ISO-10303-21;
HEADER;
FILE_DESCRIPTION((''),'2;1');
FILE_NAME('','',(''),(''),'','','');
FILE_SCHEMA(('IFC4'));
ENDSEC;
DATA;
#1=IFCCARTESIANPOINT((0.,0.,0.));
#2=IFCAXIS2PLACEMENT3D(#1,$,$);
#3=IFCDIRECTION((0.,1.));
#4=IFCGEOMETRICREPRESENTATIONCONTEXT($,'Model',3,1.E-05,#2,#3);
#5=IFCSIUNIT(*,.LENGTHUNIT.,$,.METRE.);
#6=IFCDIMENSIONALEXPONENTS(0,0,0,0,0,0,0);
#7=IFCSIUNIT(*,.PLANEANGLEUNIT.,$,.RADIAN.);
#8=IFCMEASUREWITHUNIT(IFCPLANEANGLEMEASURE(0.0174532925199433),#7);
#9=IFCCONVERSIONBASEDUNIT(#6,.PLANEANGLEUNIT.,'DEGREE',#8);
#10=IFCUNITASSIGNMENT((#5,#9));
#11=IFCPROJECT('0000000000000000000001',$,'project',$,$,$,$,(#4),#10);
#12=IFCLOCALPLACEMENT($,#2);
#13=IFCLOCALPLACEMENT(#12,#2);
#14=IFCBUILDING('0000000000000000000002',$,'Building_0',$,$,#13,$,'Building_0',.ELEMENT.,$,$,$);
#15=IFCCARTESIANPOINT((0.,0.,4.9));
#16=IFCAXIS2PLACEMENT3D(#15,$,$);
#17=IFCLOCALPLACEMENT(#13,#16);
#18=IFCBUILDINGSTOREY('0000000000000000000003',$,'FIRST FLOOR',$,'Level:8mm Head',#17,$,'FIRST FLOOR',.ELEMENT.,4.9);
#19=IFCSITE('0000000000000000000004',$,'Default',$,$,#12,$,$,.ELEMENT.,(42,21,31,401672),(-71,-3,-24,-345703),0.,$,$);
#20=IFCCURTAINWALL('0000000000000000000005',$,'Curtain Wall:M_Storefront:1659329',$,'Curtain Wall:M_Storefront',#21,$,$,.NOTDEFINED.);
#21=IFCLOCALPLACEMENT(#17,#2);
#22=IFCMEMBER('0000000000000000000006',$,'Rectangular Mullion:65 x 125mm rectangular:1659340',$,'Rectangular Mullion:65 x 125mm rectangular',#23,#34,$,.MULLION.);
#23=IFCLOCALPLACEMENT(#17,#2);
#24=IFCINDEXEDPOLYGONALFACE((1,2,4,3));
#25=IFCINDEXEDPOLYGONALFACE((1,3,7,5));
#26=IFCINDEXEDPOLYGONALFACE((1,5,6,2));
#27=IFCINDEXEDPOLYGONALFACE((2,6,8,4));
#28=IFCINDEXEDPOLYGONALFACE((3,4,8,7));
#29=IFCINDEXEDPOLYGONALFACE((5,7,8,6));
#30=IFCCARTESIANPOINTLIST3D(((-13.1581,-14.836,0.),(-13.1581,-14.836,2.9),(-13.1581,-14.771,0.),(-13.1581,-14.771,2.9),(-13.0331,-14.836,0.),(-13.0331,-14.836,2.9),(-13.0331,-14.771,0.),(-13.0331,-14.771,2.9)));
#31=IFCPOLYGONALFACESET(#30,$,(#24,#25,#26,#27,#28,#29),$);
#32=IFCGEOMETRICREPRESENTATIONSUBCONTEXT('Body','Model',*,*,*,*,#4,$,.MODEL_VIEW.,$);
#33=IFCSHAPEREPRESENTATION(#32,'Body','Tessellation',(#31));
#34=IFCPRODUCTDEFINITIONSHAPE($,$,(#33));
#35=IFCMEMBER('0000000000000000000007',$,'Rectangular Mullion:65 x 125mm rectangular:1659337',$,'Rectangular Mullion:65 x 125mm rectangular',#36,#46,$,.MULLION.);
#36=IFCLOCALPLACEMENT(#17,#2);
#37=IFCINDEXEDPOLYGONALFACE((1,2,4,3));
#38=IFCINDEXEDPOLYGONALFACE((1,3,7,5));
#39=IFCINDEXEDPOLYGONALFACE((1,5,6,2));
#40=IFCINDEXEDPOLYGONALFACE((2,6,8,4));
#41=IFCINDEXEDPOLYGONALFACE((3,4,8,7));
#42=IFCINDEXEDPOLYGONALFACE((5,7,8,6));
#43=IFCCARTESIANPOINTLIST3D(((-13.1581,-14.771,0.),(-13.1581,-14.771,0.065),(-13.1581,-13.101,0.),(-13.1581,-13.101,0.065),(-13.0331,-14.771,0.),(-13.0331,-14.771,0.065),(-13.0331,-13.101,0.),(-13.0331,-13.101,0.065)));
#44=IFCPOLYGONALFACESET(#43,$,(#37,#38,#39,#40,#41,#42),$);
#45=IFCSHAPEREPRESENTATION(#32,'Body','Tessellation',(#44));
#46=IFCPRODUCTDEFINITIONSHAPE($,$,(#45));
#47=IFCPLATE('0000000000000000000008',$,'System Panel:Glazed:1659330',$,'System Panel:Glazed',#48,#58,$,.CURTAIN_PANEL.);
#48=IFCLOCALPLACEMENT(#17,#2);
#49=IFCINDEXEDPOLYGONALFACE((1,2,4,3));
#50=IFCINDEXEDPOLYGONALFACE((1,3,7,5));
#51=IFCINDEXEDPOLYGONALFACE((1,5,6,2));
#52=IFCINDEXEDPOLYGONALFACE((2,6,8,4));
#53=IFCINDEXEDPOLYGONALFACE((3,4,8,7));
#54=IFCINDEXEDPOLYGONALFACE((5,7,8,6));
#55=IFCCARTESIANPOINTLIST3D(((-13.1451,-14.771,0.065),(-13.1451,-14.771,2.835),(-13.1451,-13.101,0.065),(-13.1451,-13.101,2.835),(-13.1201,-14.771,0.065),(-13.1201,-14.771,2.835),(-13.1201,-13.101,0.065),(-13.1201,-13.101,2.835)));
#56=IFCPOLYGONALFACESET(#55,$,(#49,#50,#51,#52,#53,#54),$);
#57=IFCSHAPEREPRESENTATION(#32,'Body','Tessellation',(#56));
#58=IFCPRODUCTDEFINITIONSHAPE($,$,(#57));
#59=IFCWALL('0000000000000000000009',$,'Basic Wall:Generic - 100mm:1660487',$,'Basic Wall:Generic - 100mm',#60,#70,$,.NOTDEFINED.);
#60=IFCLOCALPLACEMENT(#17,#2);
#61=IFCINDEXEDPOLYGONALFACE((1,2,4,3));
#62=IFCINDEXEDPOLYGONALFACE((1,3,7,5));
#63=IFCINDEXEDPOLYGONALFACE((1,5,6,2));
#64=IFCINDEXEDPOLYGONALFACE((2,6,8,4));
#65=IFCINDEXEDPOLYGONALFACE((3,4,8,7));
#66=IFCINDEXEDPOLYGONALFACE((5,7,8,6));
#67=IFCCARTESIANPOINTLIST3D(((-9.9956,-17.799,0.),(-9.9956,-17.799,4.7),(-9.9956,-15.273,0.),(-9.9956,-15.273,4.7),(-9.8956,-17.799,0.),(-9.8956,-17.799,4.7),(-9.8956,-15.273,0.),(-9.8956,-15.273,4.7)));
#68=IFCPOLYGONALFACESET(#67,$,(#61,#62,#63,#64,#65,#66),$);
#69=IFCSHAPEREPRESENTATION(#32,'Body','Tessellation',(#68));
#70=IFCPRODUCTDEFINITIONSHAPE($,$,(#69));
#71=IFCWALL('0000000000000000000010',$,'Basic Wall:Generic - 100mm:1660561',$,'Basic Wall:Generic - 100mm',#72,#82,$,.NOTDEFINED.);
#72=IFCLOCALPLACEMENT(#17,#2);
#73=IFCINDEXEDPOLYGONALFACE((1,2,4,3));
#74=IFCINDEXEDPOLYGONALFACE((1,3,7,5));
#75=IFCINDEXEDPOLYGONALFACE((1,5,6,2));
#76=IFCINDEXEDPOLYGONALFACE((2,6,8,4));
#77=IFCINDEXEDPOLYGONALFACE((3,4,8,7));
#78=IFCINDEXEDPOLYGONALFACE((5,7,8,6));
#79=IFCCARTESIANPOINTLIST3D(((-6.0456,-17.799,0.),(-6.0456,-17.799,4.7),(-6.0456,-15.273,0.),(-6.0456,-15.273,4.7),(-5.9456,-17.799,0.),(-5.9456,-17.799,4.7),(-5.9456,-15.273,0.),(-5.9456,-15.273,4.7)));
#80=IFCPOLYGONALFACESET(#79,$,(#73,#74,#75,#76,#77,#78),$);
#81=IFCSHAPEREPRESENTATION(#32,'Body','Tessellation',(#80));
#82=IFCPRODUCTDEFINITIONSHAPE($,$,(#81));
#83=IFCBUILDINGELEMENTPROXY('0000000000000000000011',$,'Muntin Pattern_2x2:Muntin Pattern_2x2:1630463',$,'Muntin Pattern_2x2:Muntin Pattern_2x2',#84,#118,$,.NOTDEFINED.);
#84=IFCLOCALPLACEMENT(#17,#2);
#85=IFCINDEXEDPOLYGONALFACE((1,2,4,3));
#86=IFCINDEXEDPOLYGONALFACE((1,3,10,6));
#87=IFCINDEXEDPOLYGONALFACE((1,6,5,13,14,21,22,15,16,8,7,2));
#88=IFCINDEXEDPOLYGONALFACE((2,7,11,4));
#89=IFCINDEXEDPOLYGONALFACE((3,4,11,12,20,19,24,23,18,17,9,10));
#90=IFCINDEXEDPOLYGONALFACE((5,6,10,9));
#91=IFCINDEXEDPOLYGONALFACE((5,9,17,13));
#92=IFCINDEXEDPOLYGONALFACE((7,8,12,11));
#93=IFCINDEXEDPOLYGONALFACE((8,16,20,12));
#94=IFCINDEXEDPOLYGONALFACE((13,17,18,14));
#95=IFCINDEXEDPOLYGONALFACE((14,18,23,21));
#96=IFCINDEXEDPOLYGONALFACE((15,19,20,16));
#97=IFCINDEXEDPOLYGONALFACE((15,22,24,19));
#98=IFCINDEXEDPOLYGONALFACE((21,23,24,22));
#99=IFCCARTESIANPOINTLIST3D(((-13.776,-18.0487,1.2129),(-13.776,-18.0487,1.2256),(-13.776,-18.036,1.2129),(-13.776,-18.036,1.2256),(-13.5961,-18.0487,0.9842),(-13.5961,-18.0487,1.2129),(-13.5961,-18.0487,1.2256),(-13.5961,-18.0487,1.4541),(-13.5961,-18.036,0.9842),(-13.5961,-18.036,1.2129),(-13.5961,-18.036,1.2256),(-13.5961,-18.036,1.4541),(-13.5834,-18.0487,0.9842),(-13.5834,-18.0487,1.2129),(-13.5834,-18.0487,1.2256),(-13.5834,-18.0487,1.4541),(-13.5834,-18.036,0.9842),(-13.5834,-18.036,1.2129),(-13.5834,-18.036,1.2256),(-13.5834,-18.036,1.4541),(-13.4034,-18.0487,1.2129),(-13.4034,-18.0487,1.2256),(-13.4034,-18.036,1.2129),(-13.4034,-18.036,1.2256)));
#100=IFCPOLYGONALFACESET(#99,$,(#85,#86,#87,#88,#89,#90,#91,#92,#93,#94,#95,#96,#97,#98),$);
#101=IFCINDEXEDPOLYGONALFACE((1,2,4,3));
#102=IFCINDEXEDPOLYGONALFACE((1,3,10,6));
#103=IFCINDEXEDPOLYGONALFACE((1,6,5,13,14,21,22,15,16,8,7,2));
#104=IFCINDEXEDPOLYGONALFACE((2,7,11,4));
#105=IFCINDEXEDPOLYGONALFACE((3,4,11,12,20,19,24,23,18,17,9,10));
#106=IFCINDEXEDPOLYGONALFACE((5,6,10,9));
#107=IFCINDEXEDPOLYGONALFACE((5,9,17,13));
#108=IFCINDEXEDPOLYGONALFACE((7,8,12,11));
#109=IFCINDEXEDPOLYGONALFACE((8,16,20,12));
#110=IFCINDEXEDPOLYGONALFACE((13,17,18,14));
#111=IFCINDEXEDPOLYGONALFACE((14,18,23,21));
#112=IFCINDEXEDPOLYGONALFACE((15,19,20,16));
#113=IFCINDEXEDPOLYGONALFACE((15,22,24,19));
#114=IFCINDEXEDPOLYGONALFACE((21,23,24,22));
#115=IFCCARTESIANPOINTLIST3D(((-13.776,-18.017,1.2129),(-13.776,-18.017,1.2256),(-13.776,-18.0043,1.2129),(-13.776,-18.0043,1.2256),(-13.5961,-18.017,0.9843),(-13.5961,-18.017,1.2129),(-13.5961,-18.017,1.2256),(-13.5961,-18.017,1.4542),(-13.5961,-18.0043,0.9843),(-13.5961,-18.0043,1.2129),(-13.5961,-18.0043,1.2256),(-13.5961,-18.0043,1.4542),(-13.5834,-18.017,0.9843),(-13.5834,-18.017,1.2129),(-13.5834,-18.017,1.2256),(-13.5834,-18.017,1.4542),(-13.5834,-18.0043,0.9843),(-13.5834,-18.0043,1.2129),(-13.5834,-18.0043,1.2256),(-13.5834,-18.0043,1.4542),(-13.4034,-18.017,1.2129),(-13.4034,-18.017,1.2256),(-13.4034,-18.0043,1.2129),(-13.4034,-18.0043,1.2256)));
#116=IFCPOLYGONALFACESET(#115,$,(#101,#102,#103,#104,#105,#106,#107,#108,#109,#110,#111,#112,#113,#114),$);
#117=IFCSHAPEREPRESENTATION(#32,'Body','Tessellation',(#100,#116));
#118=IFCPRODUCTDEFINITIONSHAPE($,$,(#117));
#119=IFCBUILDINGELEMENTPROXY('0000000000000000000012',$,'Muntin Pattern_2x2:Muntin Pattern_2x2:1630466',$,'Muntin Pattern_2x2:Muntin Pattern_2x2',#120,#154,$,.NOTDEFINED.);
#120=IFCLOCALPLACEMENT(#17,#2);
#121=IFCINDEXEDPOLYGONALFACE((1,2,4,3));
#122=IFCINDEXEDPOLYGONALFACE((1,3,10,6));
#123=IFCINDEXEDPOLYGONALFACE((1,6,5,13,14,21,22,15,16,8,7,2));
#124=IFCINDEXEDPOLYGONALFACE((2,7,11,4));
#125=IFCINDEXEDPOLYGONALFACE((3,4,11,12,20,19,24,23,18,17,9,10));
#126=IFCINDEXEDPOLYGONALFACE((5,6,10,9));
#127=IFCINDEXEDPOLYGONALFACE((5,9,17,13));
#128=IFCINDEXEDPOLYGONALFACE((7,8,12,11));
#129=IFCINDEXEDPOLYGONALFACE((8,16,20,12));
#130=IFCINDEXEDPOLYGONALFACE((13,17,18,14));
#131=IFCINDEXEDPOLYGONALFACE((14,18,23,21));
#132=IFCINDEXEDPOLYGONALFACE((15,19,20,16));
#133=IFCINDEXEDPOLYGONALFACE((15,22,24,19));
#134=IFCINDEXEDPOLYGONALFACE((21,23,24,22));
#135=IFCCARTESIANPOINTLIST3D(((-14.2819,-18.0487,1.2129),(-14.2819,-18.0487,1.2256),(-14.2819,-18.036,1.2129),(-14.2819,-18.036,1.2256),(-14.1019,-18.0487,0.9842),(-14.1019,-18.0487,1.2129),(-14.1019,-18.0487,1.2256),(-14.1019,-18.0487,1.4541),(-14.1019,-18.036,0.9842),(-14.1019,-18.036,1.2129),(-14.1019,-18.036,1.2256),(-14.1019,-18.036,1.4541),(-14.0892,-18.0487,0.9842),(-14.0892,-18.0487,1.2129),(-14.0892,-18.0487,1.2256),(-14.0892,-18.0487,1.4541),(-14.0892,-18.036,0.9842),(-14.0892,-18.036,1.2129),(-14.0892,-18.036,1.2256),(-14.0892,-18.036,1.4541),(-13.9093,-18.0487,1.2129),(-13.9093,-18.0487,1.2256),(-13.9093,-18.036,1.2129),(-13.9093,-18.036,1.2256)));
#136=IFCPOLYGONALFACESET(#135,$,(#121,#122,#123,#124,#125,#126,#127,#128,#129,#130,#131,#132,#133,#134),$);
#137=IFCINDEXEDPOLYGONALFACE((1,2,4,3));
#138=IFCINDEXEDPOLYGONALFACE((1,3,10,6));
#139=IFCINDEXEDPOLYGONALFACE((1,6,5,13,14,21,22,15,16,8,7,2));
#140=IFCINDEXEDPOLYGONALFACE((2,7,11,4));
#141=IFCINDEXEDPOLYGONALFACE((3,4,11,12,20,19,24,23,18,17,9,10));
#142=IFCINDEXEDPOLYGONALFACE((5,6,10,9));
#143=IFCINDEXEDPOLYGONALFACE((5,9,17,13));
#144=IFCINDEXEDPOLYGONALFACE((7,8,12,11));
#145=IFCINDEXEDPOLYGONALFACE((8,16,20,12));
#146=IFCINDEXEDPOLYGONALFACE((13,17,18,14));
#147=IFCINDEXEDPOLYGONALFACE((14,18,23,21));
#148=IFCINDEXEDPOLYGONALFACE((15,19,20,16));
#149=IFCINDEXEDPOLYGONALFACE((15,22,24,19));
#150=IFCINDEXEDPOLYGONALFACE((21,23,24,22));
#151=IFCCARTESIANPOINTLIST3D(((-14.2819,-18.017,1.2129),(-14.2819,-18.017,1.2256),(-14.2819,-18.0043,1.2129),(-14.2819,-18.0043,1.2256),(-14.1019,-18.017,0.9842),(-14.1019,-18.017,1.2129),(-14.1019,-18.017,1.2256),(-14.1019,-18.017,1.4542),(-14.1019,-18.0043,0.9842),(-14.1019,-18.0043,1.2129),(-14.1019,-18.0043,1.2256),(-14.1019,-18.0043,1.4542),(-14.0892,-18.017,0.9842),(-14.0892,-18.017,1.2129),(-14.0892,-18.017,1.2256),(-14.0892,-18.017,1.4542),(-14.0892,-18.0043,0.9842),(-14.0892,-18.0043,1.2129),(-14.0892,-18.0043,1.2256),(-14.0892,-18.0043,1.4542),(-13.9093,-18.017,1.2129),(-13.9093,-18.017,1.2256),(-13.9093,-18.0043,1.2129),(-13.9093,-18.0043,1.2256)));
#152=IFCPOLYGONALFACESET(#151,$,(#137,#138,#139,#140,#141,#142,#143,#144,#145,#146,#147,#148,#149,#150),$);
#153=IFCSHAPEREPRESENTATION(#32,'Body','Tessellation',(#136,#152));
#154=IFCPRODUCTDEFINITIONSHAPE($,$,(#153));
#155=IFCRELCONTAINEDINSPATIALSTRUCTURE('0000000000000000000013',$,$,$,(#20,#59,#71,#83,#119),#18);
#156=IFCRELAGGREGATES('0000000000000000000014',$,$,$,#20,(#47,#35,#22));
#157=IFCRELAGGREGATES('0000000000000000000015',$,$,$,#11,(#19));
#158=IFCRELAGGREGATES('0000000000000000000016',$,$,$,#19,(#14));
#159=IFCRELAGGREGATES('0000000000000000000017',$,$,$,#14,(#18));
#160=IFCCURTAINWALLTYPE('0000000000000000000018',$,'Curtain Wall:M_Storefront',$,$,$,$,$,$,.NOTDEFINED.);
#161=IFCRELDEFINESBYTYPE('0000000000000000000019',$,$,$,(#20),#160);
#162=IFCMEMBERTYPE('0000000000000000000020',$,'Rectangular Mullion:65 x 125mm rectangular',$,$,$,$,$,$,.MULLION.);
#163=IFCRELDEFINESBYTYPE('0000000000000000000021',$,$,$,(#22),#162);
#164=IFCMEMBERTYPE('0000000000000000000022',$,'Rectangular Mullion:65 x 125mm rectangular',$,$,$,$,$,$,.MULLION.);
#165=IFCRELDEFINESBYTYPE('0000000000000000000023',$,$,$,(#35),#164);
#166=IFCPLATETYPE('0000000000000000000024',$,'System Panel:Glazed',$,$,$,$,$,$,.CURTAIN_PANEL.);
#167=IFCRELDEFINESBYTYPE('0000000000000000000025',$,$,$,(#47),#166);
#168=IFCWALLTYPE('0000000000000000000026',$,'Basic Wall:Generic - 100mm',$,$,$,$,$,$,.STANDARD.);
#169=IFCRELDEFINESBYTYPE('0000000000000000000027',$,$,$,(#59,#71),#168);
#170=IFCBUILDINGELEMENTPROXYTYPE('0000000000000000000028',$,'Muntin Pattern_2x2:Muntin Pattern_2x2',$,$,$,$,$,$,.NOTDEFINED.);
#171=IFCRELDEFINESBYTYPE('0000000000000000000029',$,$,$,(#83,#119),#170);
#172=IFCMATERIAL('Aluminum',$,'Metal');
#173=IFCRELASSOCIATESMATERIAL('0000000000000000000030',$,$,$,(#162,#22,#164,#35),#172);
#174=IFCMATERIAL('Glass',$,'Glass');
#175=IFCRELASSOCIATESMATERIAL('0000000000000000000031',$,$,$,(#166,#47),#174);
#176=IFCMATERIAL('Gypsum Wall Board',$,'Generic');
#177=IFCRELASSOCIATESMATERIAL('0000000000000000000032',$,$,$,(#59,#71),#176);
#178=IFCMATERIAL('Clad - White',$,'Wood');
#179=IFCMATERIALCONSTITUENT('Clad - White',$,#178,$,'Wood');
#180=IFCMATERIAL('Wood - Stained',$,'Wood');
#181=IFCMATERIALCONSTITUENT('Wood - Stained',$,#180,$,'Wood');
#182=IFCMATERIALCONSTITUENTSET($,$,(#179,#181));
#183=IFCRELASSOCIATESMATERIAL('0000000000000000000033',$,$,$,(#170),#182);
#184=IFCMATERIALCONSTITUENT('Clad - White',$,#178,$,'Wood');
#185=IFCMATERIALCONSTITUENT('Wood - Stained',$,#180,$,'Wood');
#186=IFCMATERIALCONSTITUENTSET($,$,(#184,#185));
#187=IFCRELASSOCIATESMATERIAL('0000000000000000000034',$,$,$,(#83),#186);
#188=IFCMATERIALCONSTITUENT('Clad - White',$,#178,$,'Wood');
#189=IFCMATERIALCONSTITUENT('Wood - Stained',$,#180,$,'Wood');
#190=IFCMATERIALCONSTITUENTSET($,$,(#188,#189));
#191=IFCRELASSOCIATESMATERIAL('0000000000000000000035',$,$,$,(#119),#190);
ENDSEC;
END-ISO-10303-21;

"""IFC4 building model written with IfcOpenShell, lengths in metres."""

from ifc_helpers import new_model, entity, si_unit, converted_unit, direction, frame, origin, place, context, subcontext, project, spatial, indexed_curve, outline, extrude, source, transform, mapped, material, constituent, constituent_set, type_object, type_shapes, element, aggregate, save


model = new_model("IFC4")

# Units and contexts
model_context = context("Model", 3, precision=1e-05, world=origin(), true_north=direction((0.0, 1.0)))
body_context = subcontext(model_context, "Body", "Model", "MODEL_VIEW")
ifc_project = project(units=[si_unit("LENGTHUNIT", "METRE"), converted_unit("PLANEANGLEUNIT", "DEGREE", entity("IfcPlaneAngleMeasure", 0.0174532925199433), si_unit("PLANEANGLEUNIT", "RADIAN"), dimensions=[0, 0, 0, 0, 0, 0, 0])], contexts=[model_context])

# Site, building, storey
site_placement = place(None, origin())
site = spatial("IfcSite", under=ifc_project, at=site_placement, Name="Default", CompositionType="ELEMENT", RefLatitude=(42, 21, 31, 401672), RefLongitude=(-71, -3, -24, -345703), RefElevation=0.0)
building_placement = place(site_placement, origin())
building = spatial("IfcBuilding", under=site, at=building_placement, Name="Building_0", LongName="Building_0", CompositionType="ELEMENT")
storey_placement = place(building_placement, frame((0.0, 0.0, 4.9)))
storey = spatial("IfcBuildingStorey", under=building, at=storey_placement, Name="FIRST FLOOR", ObjectType="Level:8mm Head", LongName="FIRST FLOOR", CompositionType="ELEMENT", Elevation=4.9)

# Curtain wall, members, plate
curtain_wall_type = type_object("IfcCurtainWallType", Name="Curtain Wall:M_Storefront", PredefinedType="NOTDEFINED")
curtain_wall_placement = place(storey_placement, frame((0.0, 0.0, -4.9)))
curtain_wall = element("IfcCurtainWall", 1, at=curtain_wall_placement, inside=storey, type_object=curtain_wall_type, Name="Curtain Wall:M_Storefront:1659329", ObjectType="Curtain Wall:M_Storefront", PredefinedType="NOTDEFINED")
ifc_material_1 = material(Name="Aluminum", Category="Metal")
member_type_1 = type_object("IfcMemberType", Name="Rectangular Mullion:65 x 125mm rectangular", PredefinedType="MULLION", material=ifc_material_1)
shared_shape_1 = source(origin(), body_context, "Body", "SweptSolid", [
    extrude(outline(indexed_curve([(-0.0325, -0.0625), (0.0325, -0.0625), (0.0325, 0.0625), (-0.0325, 0.0625), (-0.0325, -0.0625)], self_intersect=False)), frame((-0.0325, 0.0, -2.9), z_axis=(0.0, 0.0, 1.0), x_axis=(-1.0, 0.0, 0.0)), (0.0, 0.0, 1.0), 2.9),
])
type_shapes(member_type_1, [shared_shape_1])
member_1_placement = place(curtain_wall_placement, frame((-13.0956, -14.836, 7.8), z_axis=(0.0, 0.0, 1.0), x_axis=(0.0, -1.0, 0.0)))
member_1 = element("IfcMember", 2, at=member_1_placement, type_object=member_type_1, material=ifc_material_1, Name="Rectangular Mullion:65 x 125mm rectangular:1659340", ObjectType="Rectangular Mullion:65 x 125mm rectangular", PredefinedType="MULLION", context=body_context, shape_type="MappedRepresentation", body=[
    mapped(shared_shape_1, transform((0.0, 0.0, 0.0), scale=1.0)),
])
member_type_2 = type_object("IfcMemberType", Name="Rectangular Mullion:65 x 125mm rectangular", PredefinedType="MULLION", material=ifc_material_1)
shared_shape_2 = source(origin(), body_context, "Body", "SweptSolid", [
    extrude(outline(indexed_curve([(-0.0325, -0.0625), (0.0325, -0.0625), (0.0325, 0.0625), (-0.0325, 0.0625), (-0.0325, -0.0625)], self_intersect=False)), frame((-0.0325, 0.0, -1.67), z_axis=(0.0, 0.0, 1.0), x_axis=(-1.0, 0.0, 0.0)), (0.0, 0.0, 1.0), 1.67),
])
type_shapes(member_type_2, [shared_shape_2])
member_2_placement = place(curtain_wall_placement, frame((-13.0956, -14.771, 4.9), z_axis=(0.0, -1.0, 0.0), x_axis=(0.0, 0.0, -1.0)))
member_2 = element("IfcMember", 3, at=member_2_placement, type_object=member_type_2, material=ifc_material_1, Name="Rectangular Mullion:65 x 125mm rectangular:1659337", ObjectType="Rectangular Mullion:65 x 125mm rectangular", PredefinedType="MULLION", context=body_context, shape_type="MappedRepresentation", body=[
    mapped(shared_shape_2, transform((0.0, 0.0, 0.0), scale=1.0)),
])
ifc_material_2 = material(Name="Glass", Category="Glass")
plate_type = type_object("IfcPlateType", Name="System Panel:Glazed", PredefinedType="CURTAIN_PANEL", material=ifc_material_2)
shared_shape_3 = source(origin(), body_context, "Body", "SweptSolid", [
    extrude(outline(indexed_curve([(-0.0125, -0.835), (0.0125, -0.835), (0.0125, 0.835), (-0.0125, 0.835), (-0.0125, -0.835)], self_intersect=False)), frame((0.0, 0.037, 0.0), z_axis=(0.0, 0.0, 1.0), x_axis=(0.0, 1.0, 0.0)), (0.0, 0.0, 1.0), 2.77),
])
type_shapes(plate_type, [shared_shape_3])
plate_placement = place(curtain_wall_placement, frame((-13.0956, -13.936, 4.965), z_axis=(0.0, 0.0, 1.0), x_axis=(0.0, 1.0, 0.0)))
plate = element("IfcPlate", 4, at=plate_placement, type_object=plate_type, material=ifc_material_2, Name="System Panel:Glazed:1659330", ObjectType="System Panel:Glazed", PredefinedType="CURTAIN_PANEL", context=body_context, shape_type="MappedRepresentation", body=[
    mapped(shared_shape_3, transform((0.0, 0.0, 0.0), scale=1.0)),
])
aggregate(curtain_wall, [plate, member_2, member_1])

# Shared definitions
ifc_material_3 = material(Name="Clad - White", Category="Wood")

# Walls
ifc_material_4 = material(Name="Gypsum Wall Board", Category="Generic")
wall_type_1 = type_object("IfcWallType", Name="Basic Wall:Generic - 100mm", PredefinedType="STANDARD")
wall_1_placement = place(storey_placement, frame((-9.9456, -15.273, 0.0), z_axis=(0.0, 0.0, 1.0), x_axis=(0.0, -1.0, 0.0)))
element("IfcWall", 5, at=wall_1_placement, inside=storey, type_object=wall_type_1, material=ifc_material_4, Name="Basic Wall:Generic - 100mm:1660487", ObjectType="Basic Wall:Generic - 100mm", PredefinedType="NOTDEFINED", context=body_context, shape_type="SweptSolid", body=[
    extrude(outline(indexed_curve([(2.526, 0.05), (0.0, 0.05), (0.0, -0.05), (2.526, -0.05), (2.526, 0.05)], self_intersect=False)), origin(), (0.0, 0.0, 1.0), 4.7),
])
wall_2_placement = place(storey_placement, frame((-5.9956, -15.273, 0.0), z_axis=(0.0, 0.0, 1.0), x_axis=(0.0, -1.0, 0.0)))
element("IfcWall", 6, at=wall_2_placement, inside=storey, type_object=wall_type_1, material=ifc_material_4, Name="Basic Wall:Generic - 100mm:1660561", ObjectType="Basic Wall:Generic - 100mm", PredefinedType="NOTDEFINED", context=body_context, shape_type="SweptSolid", body=[
    extrude(outline(indexed_curve([(2.526, 0.05), (0.0, 0.05), (0.0, -0.05), (2.526, -0.05), (2.526, 0.05)], self_intersect=False)), origin(), (0.0, 0.0, 1.0), 4.7),
])

# Building element proxies
ifc_constituent_1 = constituent(ifc_material_3, Name="Clad - White", Category="Wood")
ifc_material_5 = material(Name="Wood - Stained", Category="Wood")
ifc_constituent_2 = constituent(ifc_material_5, Name="Wood - Stained", Category="Wood")
ifc_constituent_set_1 = constituent_set(constituents=[ifc_constituent_1, ifc_constituent_2])
ifc_constituent_3 = constituent(ifc_material_3, Name="Clad - White", Category="Wood")
ifc_constituent_4 = constituent(ifc_material_5, Name="Wood - Stained", Category="Wood")
ifc_constituent_set_2 = constituent_set(constituents=[ifc_constituent_3, ifc_constituent_4])
building_element_proxy_type_1 = type_object("IfcBuildingElementProxyType", Name="Muntin Pattern_2x2:Muntin Pattern_2x2", PredefinedType="NOTDEFINED", material=ifc_constituent_set_2)
shared_shape_4 = source(origin(), body_context, "Body", "SweptSolid", [
    extrude(outline(indexed_curve([(0.0064, -0.0064), (0.2349, -0.0064), (0.2349, 0.0063), (0.0064, 0.0063), (0.0064, 0.1863), (-0.0063, 0.1863), (-0.0063, 0.0063), (-0.235, 0.0063), (-0.235, -0.0064), (-0.0063, -0.0064), (-0.0063, -0.1863), (0.0064, -0.1863), (0.0064, -0.0064)], self_intersect=False)), frame((0.0, 0.0095, 0.235), z_axis=(0.0, 1.0, 0.0), x_axis=(0.0, 0.0, 1.0)), (0.0, 0.0, 1.0), 0.0127),
    extrude(outline(indexed_curve([(0.0064, -0.0064), (0.235, -0.0064), (0.235, 0.0063), (0.0064, 0.0063), (0.0064, 0.1863), (-0.0063, 0.1863), (-0.0063, 0.0063), (-0.235, 0.0063), (-0.235, -0.0064), (-0.0063, -0.0064), (-0.0063, -0.1863), (0.0064, -0.1863), (0.0064, -0.0064)], self_intersect=False)), frame((0.0, -0.0222, 0.235), z_axis=(0.0, 1.0, 0.0), x_axis=(0.0, 0.0, 1.0)), (0.0, 0.0, 1.0), 0.0127),
])
type_shapes(building_element_proxy_type_1, [shared_shape_4])
proxy_1_placement = place(storey_placement, frame((-13.5897, -18.0265, 0.9843), z_axis=(0.0, 0.0, 1.0), x_axis=(-1.0, 0.0, 0.0)))
element("IfcBuildingElementProxy", 7, at=proxy_1_placement, inside=storey, type_object=building_element_proxy_type_1, material=ifc_constituent_set_1, Name="Muntin Pattern_2x2:Muntin Pattern_2x2:1630463", ObjectType="Muntin Pattern_2x2:Muntin Pattern_2x2", PredefinedType="NOTDEFINED", context=body_context, shape_type="MappedRepresentation", body=[
    mapped(shared_shape_4, transform((0.0, 0.0, 0.0), scale=1.0)),
])
ifc_constituent_5 = constituent(ifc_material_3, Name="Clad - White", Category="Wood")
ifc_constituent_6 = constituent(ifc_material_5, Name="Wood - Stained", Category="Wood")
ifc_constituent_set_3 = constituent_set(constituents=[ifc_constituent_5, ifc_constituent_6])
proxy_2_placement = place(storey_placement, frame((-14.0956, -18.0265, 0.9842), z_axis=(0.0, 0.0, 1.0), x_axis=(-1.0, 0.0, 0.0)))
element("IfcBuildingElementProxy", 8, at=proxy_2_placement, inside=storey, type_object=building_element_proxy_type_1, material=ifc_constituent_set_3, Name="Muntin Pattern_2x2:Muntin Pattern_2x2:1630466", ObjectType="Muntin Pattern_2x2:Muntin Pattern_2x2", PredefinedType="NOTDEFINED", context=body_context, shape_type="MappedRepresentation", body=[
    mapped(shared_shape_4, transform((0.0, 0.0, 0.0), scale=1.0)),
])

save(model, "model.ifc")
